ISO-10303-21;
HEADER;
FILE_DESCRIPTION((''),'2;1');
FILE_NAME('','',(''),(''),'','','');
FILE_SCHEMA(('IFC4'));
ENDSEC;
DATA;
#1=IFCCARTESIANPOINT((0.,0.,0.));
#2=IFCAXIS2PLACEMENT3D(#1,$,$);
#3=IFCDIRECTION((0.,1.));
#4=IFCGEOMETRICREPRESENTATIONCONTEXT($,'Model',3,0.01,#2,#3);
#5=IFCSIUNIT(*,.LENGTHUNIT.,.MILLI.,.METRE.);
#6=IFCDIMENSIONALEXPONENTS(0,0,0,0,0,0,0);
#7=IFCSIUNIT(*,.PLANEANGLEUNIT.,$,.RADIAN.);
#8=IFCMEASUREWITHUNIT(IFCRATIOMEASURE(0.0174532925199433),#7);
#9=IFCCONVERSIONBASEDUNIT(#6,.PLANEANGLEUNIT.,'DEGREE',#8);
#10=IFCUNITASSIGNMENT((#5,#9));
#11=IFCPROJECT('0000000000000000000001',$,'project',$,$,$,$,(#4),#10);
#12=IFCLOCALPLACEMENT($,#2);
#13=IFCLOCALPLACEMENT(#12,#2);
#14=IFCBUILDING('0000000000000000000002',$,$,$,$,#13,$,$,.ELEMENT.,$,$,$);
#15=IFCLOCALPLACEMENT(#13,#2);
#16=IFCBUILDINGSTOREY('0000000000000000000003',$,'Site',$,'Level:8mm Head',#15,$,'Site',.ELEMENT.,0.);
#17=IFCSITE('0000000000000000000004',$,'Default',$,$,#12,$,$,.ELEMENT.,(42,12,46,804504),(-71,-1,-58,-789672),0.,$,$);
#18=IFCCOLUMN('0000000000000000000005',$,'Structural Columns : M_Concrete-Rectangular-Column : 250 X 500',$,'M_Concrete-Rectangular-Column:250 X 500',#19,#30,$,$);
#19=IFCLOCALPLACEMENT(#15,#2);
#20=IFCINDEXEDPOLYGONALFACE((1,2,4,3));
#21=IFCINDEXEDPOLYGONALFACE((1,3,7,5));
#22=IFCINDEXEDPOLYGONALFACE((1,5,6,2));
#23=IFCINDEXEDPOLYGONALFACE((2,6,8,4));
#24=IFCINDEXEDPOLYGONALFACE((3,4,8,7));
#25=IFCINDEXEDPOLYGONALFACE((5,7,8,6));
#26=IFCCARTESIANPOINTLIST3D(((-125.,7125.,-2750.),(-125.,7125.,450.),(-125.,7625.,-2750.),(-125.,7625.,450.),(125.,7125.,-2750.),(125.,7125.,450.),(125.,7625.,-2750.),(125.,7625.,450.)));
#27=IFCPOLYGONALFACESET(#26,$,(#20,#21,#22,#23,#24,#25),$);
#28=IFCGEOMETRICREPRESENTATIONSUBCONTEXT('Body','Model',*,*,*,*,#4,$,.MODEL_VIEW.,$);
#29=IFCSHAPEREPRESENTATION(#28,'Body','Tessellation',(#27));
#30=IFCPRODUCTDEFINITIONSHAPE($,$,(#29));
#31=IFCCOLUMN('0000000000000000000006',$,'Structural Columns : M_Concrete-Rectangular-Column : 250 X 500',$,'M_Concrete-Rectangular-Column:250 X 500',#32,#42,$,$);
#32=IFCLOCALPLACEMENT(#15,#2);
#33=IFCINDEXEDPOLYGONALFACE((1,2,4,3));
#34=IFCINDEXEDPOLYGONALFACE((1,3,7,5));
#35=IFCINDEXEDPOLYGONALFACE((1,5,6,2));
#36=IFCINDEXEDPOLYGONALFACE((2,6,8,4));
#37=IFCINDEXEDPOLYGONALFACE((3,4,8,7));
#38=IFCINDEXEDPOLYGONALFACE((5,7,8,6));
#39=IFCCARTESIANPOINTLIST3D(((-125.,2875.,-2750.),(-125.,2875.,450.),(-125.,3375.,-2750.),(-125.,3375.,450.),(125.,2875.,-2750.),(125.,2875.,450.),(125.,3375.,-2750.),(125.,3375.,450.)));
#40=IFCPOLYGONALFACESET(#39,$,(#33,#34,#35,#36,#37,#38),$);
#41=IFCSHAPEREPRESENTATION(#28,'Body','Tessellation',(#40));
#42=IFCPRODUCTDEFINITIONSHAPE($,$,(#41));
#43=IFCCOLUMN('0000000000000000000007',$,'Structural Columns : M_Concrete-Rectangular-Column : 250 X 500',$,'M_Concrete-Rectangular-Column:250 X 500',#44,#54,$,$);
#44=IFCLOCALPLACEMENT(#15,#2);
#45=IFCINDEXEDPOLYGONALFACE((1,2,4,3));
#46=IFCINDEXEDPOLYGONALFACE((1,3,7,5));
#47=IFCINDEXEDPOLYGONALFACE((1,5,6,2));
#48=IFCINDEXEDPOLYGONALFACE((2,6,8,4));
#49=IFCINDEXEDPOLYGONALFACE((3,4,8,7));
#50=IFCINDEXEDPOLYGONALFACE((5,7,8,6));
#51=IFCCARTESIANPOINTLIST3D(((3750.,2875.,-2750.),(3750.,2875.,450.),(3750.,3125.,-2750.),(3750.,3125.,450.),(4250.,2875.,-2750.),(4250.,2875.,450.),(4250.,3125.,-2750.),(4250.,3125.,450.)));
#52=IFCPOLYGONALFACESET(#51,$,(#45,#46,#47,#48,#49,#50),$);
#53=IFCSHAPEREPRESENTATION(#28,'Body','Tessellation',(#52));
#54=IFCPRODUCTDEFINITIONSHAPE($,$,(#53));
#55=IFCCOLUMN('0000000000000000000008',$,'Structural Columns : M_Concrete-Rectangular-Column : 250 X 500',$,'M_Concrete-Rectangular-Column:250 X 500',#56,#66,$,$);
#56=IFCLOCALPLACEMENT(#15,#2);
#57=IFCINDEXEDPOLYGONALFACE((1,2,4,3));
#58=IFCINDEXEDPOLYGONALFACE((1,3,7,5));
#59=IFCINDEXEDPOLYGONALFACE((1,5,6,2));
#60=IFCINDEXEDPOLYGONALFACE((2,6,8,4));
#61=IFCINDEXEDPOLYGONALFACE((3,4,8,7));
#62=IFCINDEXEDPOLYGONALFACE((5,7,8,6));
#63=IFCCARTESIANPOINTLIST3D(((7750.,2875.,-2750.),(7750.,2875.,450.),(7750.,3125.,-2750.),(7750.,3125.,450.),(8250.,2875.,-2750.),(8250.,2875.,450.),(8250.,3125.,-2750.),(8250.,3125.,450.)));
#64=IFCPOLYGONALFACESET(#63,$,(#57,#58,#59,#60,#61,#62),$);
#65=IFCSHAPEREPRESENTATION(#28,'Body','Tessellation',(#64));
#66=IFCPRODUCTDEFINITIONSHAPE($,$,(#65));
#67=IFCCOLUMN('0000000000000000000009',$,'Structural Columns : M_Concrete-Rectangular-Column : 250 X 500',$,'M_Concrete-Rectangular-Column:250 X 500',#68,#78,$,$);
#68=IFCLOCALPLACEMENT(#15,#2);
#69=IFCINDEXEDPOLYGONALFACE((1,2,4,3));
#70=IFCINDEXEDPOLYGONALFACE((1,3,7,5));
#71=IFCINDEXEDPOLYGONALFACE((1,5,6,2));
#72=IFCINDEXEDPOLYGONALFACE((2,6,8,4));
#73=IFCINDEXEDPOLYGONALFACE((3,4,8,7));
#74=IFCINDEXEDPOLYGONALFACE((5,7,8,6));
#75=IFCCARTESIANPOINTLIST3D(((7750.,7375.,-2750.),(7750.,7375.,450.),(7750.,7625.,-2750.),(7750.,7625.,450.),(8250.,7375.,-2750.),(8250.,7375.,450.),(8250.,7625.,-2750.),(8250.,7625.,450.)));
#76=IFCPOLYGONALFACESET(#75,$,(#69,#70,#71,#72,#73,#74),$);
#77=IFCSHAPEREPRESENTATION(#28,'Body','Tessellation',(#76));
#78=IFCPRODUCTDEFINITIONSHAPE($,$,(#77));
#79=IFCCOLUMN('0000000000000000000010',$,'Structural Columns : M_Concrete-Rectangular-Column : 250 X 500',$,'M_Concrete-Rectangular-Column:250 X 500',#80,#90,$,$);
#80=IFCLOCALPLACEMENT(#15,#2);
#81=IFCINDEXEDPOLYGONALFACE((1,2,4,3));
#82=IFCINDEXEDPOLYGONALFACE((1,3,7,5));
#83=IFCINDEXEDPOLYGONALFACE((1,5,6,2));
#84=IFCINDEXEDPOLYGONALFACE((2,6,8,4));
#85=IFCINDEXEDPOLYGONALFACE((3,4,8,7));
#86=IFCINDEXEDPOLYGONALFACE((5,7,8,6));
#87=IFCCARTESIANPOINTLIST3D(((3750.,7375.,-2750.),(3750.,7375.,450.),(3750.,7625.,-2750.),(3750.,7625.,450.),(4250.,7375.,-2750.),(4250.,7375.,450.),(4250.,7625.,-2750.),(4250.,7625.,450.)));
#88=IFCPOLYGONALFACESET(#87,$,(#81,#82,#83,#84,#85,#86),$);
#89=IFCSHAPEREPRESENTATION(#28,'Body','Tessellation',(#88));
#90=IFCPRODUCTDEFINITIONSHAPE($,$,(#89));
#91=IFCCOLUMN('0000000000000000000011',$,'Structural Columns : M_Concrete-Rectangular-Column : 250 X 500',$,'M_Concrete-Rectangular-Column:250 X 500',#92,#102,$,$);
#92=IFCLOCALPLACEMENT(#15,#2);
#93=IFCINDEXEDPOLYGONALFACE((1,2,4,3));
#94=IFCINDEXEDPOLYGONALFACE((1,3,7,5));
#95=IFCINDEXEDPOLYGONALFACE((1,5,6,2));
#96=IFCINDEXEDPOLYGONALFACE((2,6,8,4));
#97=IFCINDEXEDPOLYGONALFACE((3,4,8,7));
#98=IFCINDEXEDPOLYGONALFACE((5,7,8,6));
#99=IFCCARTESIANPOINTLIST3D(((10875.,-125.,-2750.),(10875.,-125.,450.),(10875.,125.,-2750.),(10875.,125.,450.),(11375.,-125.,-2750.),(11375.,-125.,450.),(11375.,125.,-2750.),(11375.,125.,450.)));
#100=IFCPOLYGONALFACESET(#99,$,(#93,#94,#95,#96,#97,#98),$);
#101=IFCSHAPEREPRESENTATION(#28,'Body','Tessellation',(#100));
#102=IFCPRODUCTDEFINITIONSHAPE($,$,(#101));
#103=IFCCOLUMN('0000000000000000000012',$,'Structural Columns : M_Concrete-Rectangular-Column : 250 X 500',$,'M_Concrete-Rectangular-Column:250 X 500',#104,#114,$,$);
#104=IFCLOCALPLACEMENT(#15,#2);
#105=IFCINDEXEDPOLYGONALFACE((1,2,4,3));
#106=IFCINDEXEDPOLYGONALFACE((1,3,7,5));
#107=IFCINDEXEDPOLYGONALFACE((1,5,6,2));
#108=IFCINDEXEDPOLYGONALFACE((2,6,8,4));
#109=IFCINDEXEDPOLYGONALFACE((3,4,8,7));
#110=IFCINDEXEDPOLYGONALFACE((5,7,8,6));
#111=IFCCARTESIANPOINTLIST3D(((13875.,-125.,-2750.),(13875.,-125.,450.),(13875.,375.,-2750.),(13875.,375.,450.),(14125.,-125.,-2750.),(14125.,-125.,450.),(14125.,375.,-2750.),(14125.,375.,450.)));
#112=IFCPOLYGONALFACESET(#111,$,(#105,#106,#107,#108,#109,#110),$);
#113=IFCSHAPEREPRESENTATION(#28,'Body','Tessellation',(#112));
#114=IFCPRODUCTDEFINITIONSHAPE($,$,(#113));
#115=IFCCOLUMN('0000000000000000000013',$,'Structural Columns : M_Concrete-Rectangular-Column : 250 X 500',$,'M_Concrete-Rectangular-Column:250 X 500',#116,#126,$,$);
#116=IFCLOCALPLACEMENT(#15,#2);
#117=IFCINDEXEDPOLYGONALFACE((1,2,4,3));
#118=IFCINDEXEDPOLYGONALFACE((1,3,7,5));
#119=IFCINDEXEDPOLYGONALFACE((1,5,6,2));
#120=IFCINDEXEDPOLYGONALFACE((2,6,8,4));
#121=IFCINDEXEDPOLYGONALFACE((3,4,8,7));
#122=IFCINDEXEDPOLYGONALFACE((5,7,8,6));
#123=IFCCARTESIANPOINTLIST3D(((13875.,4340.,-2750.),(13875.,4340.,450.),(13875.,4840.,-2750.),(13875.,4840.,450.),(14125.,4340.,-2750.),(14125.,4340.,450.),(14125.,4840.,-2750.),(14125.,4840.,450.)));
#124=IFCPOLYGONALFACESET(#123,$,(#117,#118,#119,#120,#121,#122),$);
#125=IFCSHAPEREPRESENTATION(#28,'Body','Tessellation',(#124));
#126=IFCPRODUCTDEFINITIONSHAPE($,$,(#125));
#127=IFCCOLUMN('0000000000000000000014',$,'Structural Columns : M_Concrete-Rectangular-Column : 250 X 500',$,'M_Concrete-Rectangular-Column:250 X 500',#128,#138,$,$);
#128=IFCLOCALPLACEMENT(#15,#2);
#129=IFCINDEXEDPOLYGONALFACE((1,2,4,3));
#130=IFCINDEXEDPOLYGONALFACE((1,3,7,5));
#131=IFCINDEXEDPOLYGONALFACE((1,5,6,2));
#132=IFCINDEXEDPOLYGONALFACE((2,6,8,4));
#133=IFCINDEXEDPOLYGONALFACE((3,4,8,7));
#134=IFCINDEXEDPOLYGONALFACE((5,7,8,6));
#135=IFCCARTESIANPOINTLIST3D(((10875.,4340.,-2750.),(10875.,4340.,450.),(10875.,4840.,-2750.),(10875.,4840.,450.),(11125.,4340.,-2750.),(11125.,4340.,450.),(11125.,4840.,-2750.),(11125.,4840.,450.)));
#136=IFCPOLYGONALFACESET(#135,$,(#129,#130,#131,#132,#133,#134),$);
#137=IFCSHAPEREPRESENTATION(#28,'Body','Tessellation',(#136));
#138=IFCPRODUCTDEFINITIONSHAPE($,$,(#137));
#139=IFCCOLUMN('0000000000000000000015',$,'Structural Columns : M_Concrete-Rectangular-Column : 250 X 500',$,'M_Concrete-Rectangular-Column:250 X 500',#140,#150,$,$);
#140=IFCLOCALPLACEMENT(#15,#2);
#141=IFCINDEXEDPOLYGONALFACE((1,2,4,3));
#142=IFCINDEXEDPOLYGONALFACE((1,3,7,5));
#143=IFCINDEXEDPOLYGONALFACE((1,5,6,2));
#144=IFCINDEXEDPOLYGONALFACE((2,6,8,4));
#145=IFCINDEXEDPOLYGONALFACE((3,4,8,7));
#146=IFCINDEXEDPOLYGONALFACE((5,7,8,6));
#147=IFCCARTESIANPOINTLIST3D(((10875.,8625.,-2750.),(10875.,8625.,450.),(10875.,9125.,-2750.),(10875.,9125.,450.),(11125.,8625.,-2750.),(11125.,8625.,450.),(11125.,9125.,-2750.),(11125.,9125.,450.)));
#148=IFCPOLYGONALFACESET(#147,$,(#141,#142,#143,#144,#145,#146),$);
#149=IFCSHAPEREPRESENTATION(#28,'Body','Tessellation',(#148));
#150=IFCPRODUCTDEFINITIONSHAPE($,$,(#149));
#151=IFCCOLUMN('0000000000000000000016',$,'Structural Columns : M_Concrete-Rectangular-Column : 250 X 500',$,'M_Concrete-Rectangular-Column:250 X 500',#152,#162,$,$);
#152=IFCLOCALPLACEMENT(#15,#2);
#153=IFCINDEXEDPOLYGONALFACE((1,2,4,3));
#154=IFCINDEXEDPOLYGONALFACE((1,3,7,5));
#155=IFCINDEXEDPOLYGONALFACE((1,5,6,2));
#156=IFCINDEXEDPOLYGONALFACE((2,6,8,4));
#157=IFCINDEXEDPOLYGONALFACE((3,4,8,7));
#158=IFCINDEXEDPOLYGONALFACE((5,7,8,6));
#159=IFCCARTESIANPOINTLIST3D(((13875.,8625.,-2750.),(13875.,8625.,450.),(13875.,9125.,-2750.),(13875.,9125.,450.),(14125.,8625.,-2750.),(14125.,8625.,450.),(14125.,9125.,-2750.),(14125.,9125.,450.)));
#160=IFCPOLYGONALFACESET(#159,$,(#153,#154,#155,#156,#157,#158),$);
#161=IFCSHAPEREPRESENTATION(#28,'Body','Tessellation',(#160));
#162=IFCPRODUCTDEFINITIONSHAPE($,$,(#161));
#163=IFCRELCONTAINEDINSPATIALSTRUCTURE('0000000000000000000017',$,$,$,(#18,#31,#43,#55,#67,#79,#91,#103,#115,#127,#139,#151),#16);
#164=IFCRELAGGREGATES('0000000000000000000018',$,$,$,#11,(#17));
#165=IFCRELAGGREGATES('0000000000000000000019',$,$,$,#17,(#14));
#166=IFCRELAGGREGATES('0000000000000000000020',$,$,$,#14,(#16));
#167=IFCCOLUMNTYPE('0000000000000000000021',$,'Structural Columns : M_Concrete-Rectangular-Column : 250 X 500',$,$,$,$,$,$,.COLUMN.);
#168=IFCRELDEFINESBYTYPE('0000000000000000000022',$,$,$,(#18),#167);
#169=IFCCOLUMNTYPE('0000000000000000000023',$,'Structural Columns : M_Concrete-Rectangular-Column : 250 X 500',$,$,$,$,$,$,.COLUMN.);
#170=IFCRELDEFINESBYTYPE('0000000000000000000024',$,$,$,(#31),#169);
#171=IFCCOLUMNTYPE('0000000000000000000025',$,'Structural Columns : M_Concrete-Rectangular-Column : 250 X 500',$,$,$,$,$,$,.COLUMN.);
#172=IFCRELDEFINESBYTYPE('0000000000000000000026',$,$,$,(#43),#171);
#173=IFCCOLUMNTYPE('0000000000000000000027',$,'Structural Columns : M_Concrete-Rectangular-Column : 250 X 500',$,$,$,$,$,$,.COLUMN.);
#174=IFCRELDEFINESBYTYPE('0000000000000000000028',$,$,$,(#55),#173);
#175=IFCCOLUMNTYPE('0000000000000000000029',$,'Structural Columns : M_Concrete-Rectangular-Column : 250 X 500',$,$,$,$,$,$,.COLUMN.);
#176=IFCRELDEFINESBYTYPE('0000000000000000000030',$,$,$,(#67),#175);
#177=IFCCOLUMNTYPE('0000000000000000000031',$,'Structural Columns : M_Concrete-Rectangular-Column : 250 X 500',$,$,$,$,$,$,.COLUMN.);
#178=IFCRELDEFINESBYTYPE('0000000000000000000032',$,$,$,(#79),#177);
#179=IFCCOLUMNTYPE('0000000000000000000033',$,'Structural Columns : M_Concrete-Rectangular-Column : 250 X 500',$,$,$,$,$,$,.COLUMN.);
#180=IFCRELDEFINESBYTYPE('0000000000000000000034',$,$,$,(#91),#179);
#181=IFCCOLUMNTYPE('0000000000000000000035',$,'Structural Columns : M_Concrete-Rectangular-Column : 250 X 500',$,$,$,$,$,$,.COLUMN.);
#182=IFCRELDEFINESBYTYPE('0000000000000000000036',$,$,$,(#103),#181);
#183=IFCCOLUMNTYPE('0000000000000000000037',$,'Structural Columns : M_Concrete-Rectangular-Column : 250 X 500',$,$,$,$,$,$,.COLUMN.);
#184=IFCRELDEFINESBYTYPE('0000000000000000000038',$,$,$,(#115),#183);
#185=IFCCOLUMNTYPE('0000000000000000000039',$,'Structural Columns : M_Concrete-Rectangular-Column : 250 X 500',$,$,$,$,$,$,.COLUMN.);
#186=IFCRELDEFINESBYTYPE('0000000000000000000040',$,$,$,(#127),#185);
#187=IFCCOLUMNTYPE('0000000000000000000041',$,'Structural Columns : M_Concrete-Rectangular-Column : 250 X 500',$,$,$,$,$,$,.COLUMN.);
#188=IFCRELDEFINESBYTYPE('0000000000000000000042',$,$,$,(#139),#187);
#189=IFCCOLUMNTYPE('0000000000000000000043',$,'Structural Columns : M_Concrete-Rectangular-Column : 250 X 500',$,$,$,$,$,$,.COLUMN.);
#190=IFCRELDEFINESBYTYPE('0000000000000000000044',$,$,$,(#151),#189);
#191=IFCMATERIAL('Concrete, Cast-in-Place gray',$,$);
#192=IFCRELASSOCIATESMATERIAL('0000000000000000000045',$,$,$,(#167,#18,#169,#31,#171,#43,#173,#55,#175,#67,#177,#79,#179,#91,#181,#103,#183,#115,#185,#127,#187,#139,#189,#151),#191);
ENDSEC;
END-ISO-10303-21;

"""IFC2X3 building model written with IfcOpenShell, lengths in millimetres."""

from ifc_helpers import new_model, entity, si_unit, converted_unit, direction, frame, frame_2d, origin, origin_2d_with_axis, place, context, subcontext, project, spatial, rectangle, extrude, source, transform, mapped, material, type_object, type_shapes, element, save


model = new_model("IFC2X3")

# Units and contexts
model_context = context("Model", 3, precision=0.01, world=origin(), true_north=direction((0.0, 1.0)))
body_context = subcontext(model_context, "Body", "Model", "MODEL_VIEW")
ifc_project = project(units=[si_unit("LENGTHUNIT", "METRE", prefix="MILLI"), converted_unit("PLANEANGLEUNIT", "DEGREE", entity("IfcRatioMeasure", 0.0174532925199433), si_unit("PLANEANGLEUNIT", "RADIAN"), dimensions=[0, 0, 0, 0, 0, 0, 0])], contexts=[model_context])

# Site, building, storey
site_placement = place(None, origin())
site = spatial("IfcSite", under=ifc_project, at=site_placement, Name="Default", CompositionType="ELEMENT", RefLatitude=(42, 12, 46, 804504), RefLongitude=(-71, -1, -58, -789672), RefElevation=0.0)
building_placement = place(site_placement, origin())
building = spatial("IfcBuilding", under=site, at=building_placement, CompositionType="ELEMENT")
storey_placement = place(building_placement, origin())
storey = spatial("IfcBuildingStorey", under=building, at=storey_placement, Name="Site", ObjectType="Level:8mm Head", LongName="Site", CompositionType="ELEMENT", Elevation=0.0)

# Columns
ifc_material = material(Name="Concrete, Cast-in-Place gray")
column_type_1 = type_object("IfcColumnType", Name="Structural Columns : M_Concrete-Rectangular-Column : 250 X 500", PredefinedType="COLUMN", material=ifc_material)
shared_shape_1 = source(origin(), body_context, "Body", "SweptSolid", [
    extrude(rectangle(XDim=500.0, YDim=250.0, at=frame_2d((0.0, 0.0), x_axis=(1.0, 0.0))), frame((0.0, 7375.0, -2750.0), z_axis=(0.0, 0.0, 1.0), x_axis=(0.0, -1.0, 0.0)), (0.0, 0.0, 1.0), 3200.0),
])
type_shapes(column_type_1, [shared_shape_1])
column_1_placement = place(storey_placement, origin())
element("IfcColumn", 1, at=column_1_placement, inside=storey, type_object=column_type_1, material=ifc_material, Name="Structural Columns : M_Concrete-Rectangular-Column : 250 X 500", ObjectType="M_Concrete-Rectangular-Column:250 X 500", context=body_context, shape_type="MappedRepresentation", body=[
    mapped(shared_shape_1, transform((0.0, 0.0, 0.0), scale=1.0)),
])
column_type_2 = type_object("IfcColumnType", Name="Structural Columns : M_Concrete-Rectangular-Column : 250 X 500", PredefinedType="COLUMN", material=ifc_material)
shared_shape_2 = source(origin(), body_context, "Body", "SweptSolid", [
    extrude(rectangle(XDim=500.0, YDim=250.0, at=origin_2d_with_axis()), frame((0.0, 3125.0, -2750.0), z_axis=(0.0, 0.0, 1.0), x_axis=(0.0, -1.0, 0.0)), (0.0, 0.0, 1.0), 3200.0),
])
type_shapes(column_type_2, [shared_shape_2])
column_2_placement = place(storey_placement, origin())
element("IfcColumn", 2, at=column_2_placement, inside=storey, type_object=column_type_2, material=ifc_material, Name="Structural Columns : M_Concrete-Rectangular-Column : 250 X 500", ObjectType="M_Concrete-Rectangular-Column:250 X 500", context=body_context, shape_type="MappedRepresentation", body=[
    mapped(shared_shape_2, transform((0.0, 0.0, 0.0), scale=1.0)),
])
column_type_3 = type_object("IfcColumnType", Name="Structural Columns : M_Concrete-Rectangular-Column : 250 X 500", PredefinedType="COLUMN", material=ifc_material)
shared_shape_3 = source(origin(), body_context, "Body", "SweptSolid", [
    extrude(rectangle(XDim=250.0, YDim=500.0, at=frame_2d((0.0, 0.0), x_axis=(1.0, 0.0))), frame((4000.0, 3000.0, -2750.0), z_axis=(0.0, 0.0, 1.0), x_axis=(0.0, -1.0, 0.0)), (0.0, 0.0, 1.0), 3200.0),
])
type_shapes(column_type_3, [shared_shape_3])
column_3_placement = place(storey_placement, origin())
element("IfcColumn", 3, at=column_3_placement, inside=storey, type_object=column_type_3, material=ifc_material, Name="Structural Columns : M_Concrete-Rectangular-Column : 250 X 500", ObjectType="M_Concrete-Rectangular-Column:250 X 500", context=body_context, shape_type="MappedRepresentation", body=[
    mapped(shared_shape_3, transform((0.0, 0.0, 0.0), scale=1.0)),
])
column_type_4 = type_object("IfcColumnType", Name="Structural Columns : M_Concrete-Rectangular-Column : 250 X 500", PredefinedType="COLUMN", material=ifc_material)
shared_shape_4 = source(origin(), body_context, "Body", "SweptSolid", [
    extrude(rectangle(XDim=250.0, YDim=500.0, at=frame_2d((0.0, 0.0), x_axis=(1.0, 0.0))), frame((8000.0, 3000.0, -2750.0), z_axis=(0.0, 0.0, 1.0), x_axis=(0.0, -1.0, 0.0)), (0.0, 0.0, 1.0), 3200.0),
])
type_shapes(column_type_4, [shared_shape_4])
column_4_placement = place(storey_placement, origin())
element("IfcColumn", 4, at=column_4_placement, inside=storey, type_object=column_type_4, material=ifc_material, Name="Structural Columns : M_Concrete-Rectangular-Column : 250 X 500", ObjectType="M_Concrete-Rectangular-Column:250 X 500", context=body_context, shape_type="MappedRepresentation", body=[
    mapped(shared_shape_4, transform((0.0, 0.0, 0.0), scale=1.0)),
])
column_type_5 = type_object("IfcColumnType", Name="Structural Columns : M_Concrete-Rectangular-Column : 250 X 500", PredefinedType="COLUMN", material=ifc_material)
shared_shape_5 = source(origin(), body_context, "Body", "SweptSolid", [
    extrude(rectangle(XDim=250.0, YDim=500.0, at=frame_2d((0.0, 0.0), x_axis=(1.0, 0.0))), frame((8000.0, 7500.0, -2750.0), z_axis=(0.0, 0.0, 1.0), x_axis=(0.0, -1.0, 0.0)), (0.0, 0.0, 1.0), 3200.0),
])
type_shapes(column_type_5, [shared_shape_5])
column_5_placement = place(storey_placement, origin())
element("IfcColumn", 5, at=column_5_placement, inside=storey, type_object=column_type_5, material=ifc_material, Name="Structural Columns : M_Concrete-Rectangular-Column : 250 X 500", ObjectType="M_Concrete-Rectangular-Column:250 X 500", context=body_context, shape_type="MappedRepresentation", body=[
    mapped(shared_shape_5, transform((0.0, 0.0, 0.0), scale=1.0)),
])
column_type_6 = type_object("IfcColumnType", Name="Structural Columns : M_Concrete-Rectangular-Column : 250 X 500", PredefinedType="COLUMN", material=ifc_material)
shared_shape_6 = source(origin(), body_context, "Body", "SweptSolid", [
    extrude(rectangle(XDim=250.0, YDim=500.0, at=origin_2d_with_axis()), frame((4000.0, 7500.0, -2750.0), z_axis=(0.0, 0.0, 1.0), x_axis=(0.0, -1.0, 0.0)), (0.0, 0.0, 1.0), 3200.0),
])
type_shapes(column_type_6, [shared_shape_6])
column_6_placement = place(storey_placement, origin())
element("IfcColumn", 6, at=column_6_placement, inside=storey, type_object=column_type_6, material=ifc_material, Name="Structural Columns : M_Concrete-Rectangular-Column : 250 X 500", ObjectType="M_Concrete-Rectangular-Column:250 X 500", context=body_context, shape_type="MappedRepresentation", body=[
    mapped(shared_shape_6, transform((0.0, 0.0, 0.0), scale=1.0)),
])
column_type_7 = type_object("IfcColumnType", Name="Structural Columns : M_Concrete-Rectangular-Column : 250 X 500", PredefinedType="COLUMN", material=ifc_material)
shared_shape_7 = source(origin(), body_context, "Body", "SweptSolid", [
    extrude(rectangle(XDim=250.0, YDim=500.0, at=origin_2d_with_axis()), frame((11125.0, 0.0, -2750.0), z_axis=(0.0, 0.0, 1.0), x_axis=(0.0, -1.0, 0.0)), (0.0, 0.0, 1.0), 3200.0),
])
type_shapes(column_type_7, [shared_shape_7])
column_7_placement = place(storey_placement, origin())
element("IfcColumn", 7, at=column_7_placement, inside=storey, type_object=column_type_7, material=ifc_material, Name="Structural Columns : M_Concrete-Rectangular-Column : 250 X 500", ObjectType="M_Concrete-Rectangular-Column:250 X 500", context=body_context, shape_type="MappedRepresentation", body=[
    mapped(shared_shape_7, transform((0.0, 0.0, 0.0), scale=1.0)),
])
column_type_8 = type_object("IfcColumnType", Name="Structural Columns : M_Concrete-Rectangular-Column : 250 X 500", PredefinedType="COLUMN", material=ifc_material)
shared_shape_8 = source(origin(), body_context, "Body", "SweptSolid", [
    extrude(rectangle(XDim=500.0, YDim=250.0, at=frame_2d((0.0, 0.0), x_axis=(1.0, 0.0))), frame((14000.0, 125.0, -2750.0), z_axis=(0.0, 0.0, 1.0), x_axis=(0.0, -1.0, 0.0)), (0.0, 0.0, 1.0), 3200.0),
])
type_shapes(column_type_8, [shared_shape_8])
column_8_placement = place(storey_placement, origin())
element("IfcColumn", 8, at=column_8_placement, inside=storey, type_object=column_type_8, material=ifc_material, Name="Structural Columns : M_Concrete-Rectangular-Column : 250 X 500", ObjectType="M_Concrete-Rectangular-Column:250 X 500", context=body_context, shape_type="MappedRepresentation", body=[
    mapped(shared_shape_8, transform((0.0, 0.0, 0.0), scale=1.0)),
])
column_type_9 = type_object("IfcColumnType", Name="Structural Columns : M_Concrete-Rectangular-Column : 250 X 500", PredefinedType="COLUMN", material=ifc_material)
shared_shape_9 = source(origin(), body_context, "Body", "SweptSolid", [
    extrude(rectangle(XDim=500.0, YDim=250.0, at=origin_2d_with_axis()), frame((14000.0, 4590.0, -2750.0), z_axis=(0.0, 0.0, 1.0), x_axis=(0.0, -1.0, 0.0)), (0.0, 0.0, 1.0), 3200.0),
])
type_shapes(column_type_9, [shared_shape_9])
column_9_placement = place(storey_placement, origin())
element("IfcColumn", 9, at=column_9_placement, inside=storey, type_object=column_type_9, material=ifc_material, Name="Structural Columns : M_Concrete-Rectangular-Column : 250 X 500", ObjectType="M_Concrete-Rectangular-Column:250 X 500", context=body_context, shape_type="MappedRepresentation", body=[
    mapped(shared_shape_9, transform((0.0, 0.0, 0.0), scale=1.0)),
])
column_type_10 = type_object("IfcColumnType", Name="Structural Columns : M_Concrete-Rectangular-Column : 250 X 500", PredefinedType="COLUMN", material=ifc_material)
shared_shape_10 = source(origin(), body_context, "Body", "SweptSolid", [
    extrude(rectangle(XDim=500.0, YDim=250.0, at=origin_2d_with_axis()), frame((11000.0, 4590.0, -2750.0), z_axis=(0.0, 0.0, 1.0), x_axis=(0.0, -1.0, 0.0)), (0.0, 0.0, 1.0), 3200.0),
])
type_shapes(column_type_10, [shared_shape_10])
column_10_placement = place(storey_placement, origin())
element("IfcColumn", 10, at=column_10_placement, inside=storey, type_object=column_type_10, material=ifc_material, Name="Structural Columns : M_Concrete-Rectangular-Column : 250 X 500", ObjectType="M_Concrete-Rectangular-Column:250 X 500", context=body_context, shape_type="MappedRepresentation", body=[
    mapped(shared_shape_10, transform((0.0, 0.0, 0.0), scale=1.0)),
])
column_type_11 = type_object("IfcColumnType", Name="Structural Columns : M_Concrete-Rectangular-Column : 250 X 500", PredefinedType="COLUMN", material=ifc_material)
shared_shape_11 = source(origin(), body_context, "Body", "SweptSolid", [
    extrude(rectangle(XDim=500.0, YDim=250.0, at=frame_2d((0.0, 0.0), x_axis=(1.0, 0.0))), frame((11000.0, 8875.0, -2750.0), z_axis=(0.0, 0.0, 1.0), x_axis=(0.0, -1.0, 0.0)), (0.0, 0.0, 1.0), 3200.0),
])
type_shapes(column_type_11, [shared_shape_11])
column_11_placement = place(storey_placement, origin())
element("IfcColumn", 11, at=column_11_placement, inside=storey, type_object=column_type_11, material=ifc_material, Name="Structural Columns : M_Concrete-Rectangular-Column : 250 X 500", ObjectType="M_Concrete-Rectangular-Column:250 X 500", context=body_context, shape_type="MappedRepresentation", body=[
    mapped(shared_shape_11, transform((0.0, 0.0, 0.0), scale=1.0)),
])
column_type_12 = type_object("IfcColumnType", Name="Structural Columns : M_Concrete-Rectangular-Column : 250 X 500", PredefinedType="COLUMN", material=ifc_material)
shared_shape_12 = source(origin(), body_context, "Body", "SweptSolid", [
    extrude(rectangle(XDim=500.0, YDim=250.0, at=frame_2d((0.0, 0.0), x_axis=(1.0, 0.0))), frame((14000.0, 8875.0, -2750.0), z_axis=(0.0, 0.0, 1.0), x_axis=(0.0, -1.0, 0.0)), (0.0, 0.0, 1.0), 3200.0),
])
type_shapes(column_type_12, [shared_shape_12])
column_12_placement = place(storey_placement, origin())
element("IfcColumn", 12, at=column_12_placement, inside=storey, type_object=column_type_12, material=ifc_material, Name="Structural Columns : M_Concrete-Rectangular-Column : 250 X 500", ObjectType="M_Concrete-Rectangular-Column:250 X 500", context=body_context, shape_type="MappedRepresentation", body=[
    mapped(shared_shape_12, transform((0.0, 0.0, 0.0), scale=1.0)),
])

save(model, "model.ifc")
